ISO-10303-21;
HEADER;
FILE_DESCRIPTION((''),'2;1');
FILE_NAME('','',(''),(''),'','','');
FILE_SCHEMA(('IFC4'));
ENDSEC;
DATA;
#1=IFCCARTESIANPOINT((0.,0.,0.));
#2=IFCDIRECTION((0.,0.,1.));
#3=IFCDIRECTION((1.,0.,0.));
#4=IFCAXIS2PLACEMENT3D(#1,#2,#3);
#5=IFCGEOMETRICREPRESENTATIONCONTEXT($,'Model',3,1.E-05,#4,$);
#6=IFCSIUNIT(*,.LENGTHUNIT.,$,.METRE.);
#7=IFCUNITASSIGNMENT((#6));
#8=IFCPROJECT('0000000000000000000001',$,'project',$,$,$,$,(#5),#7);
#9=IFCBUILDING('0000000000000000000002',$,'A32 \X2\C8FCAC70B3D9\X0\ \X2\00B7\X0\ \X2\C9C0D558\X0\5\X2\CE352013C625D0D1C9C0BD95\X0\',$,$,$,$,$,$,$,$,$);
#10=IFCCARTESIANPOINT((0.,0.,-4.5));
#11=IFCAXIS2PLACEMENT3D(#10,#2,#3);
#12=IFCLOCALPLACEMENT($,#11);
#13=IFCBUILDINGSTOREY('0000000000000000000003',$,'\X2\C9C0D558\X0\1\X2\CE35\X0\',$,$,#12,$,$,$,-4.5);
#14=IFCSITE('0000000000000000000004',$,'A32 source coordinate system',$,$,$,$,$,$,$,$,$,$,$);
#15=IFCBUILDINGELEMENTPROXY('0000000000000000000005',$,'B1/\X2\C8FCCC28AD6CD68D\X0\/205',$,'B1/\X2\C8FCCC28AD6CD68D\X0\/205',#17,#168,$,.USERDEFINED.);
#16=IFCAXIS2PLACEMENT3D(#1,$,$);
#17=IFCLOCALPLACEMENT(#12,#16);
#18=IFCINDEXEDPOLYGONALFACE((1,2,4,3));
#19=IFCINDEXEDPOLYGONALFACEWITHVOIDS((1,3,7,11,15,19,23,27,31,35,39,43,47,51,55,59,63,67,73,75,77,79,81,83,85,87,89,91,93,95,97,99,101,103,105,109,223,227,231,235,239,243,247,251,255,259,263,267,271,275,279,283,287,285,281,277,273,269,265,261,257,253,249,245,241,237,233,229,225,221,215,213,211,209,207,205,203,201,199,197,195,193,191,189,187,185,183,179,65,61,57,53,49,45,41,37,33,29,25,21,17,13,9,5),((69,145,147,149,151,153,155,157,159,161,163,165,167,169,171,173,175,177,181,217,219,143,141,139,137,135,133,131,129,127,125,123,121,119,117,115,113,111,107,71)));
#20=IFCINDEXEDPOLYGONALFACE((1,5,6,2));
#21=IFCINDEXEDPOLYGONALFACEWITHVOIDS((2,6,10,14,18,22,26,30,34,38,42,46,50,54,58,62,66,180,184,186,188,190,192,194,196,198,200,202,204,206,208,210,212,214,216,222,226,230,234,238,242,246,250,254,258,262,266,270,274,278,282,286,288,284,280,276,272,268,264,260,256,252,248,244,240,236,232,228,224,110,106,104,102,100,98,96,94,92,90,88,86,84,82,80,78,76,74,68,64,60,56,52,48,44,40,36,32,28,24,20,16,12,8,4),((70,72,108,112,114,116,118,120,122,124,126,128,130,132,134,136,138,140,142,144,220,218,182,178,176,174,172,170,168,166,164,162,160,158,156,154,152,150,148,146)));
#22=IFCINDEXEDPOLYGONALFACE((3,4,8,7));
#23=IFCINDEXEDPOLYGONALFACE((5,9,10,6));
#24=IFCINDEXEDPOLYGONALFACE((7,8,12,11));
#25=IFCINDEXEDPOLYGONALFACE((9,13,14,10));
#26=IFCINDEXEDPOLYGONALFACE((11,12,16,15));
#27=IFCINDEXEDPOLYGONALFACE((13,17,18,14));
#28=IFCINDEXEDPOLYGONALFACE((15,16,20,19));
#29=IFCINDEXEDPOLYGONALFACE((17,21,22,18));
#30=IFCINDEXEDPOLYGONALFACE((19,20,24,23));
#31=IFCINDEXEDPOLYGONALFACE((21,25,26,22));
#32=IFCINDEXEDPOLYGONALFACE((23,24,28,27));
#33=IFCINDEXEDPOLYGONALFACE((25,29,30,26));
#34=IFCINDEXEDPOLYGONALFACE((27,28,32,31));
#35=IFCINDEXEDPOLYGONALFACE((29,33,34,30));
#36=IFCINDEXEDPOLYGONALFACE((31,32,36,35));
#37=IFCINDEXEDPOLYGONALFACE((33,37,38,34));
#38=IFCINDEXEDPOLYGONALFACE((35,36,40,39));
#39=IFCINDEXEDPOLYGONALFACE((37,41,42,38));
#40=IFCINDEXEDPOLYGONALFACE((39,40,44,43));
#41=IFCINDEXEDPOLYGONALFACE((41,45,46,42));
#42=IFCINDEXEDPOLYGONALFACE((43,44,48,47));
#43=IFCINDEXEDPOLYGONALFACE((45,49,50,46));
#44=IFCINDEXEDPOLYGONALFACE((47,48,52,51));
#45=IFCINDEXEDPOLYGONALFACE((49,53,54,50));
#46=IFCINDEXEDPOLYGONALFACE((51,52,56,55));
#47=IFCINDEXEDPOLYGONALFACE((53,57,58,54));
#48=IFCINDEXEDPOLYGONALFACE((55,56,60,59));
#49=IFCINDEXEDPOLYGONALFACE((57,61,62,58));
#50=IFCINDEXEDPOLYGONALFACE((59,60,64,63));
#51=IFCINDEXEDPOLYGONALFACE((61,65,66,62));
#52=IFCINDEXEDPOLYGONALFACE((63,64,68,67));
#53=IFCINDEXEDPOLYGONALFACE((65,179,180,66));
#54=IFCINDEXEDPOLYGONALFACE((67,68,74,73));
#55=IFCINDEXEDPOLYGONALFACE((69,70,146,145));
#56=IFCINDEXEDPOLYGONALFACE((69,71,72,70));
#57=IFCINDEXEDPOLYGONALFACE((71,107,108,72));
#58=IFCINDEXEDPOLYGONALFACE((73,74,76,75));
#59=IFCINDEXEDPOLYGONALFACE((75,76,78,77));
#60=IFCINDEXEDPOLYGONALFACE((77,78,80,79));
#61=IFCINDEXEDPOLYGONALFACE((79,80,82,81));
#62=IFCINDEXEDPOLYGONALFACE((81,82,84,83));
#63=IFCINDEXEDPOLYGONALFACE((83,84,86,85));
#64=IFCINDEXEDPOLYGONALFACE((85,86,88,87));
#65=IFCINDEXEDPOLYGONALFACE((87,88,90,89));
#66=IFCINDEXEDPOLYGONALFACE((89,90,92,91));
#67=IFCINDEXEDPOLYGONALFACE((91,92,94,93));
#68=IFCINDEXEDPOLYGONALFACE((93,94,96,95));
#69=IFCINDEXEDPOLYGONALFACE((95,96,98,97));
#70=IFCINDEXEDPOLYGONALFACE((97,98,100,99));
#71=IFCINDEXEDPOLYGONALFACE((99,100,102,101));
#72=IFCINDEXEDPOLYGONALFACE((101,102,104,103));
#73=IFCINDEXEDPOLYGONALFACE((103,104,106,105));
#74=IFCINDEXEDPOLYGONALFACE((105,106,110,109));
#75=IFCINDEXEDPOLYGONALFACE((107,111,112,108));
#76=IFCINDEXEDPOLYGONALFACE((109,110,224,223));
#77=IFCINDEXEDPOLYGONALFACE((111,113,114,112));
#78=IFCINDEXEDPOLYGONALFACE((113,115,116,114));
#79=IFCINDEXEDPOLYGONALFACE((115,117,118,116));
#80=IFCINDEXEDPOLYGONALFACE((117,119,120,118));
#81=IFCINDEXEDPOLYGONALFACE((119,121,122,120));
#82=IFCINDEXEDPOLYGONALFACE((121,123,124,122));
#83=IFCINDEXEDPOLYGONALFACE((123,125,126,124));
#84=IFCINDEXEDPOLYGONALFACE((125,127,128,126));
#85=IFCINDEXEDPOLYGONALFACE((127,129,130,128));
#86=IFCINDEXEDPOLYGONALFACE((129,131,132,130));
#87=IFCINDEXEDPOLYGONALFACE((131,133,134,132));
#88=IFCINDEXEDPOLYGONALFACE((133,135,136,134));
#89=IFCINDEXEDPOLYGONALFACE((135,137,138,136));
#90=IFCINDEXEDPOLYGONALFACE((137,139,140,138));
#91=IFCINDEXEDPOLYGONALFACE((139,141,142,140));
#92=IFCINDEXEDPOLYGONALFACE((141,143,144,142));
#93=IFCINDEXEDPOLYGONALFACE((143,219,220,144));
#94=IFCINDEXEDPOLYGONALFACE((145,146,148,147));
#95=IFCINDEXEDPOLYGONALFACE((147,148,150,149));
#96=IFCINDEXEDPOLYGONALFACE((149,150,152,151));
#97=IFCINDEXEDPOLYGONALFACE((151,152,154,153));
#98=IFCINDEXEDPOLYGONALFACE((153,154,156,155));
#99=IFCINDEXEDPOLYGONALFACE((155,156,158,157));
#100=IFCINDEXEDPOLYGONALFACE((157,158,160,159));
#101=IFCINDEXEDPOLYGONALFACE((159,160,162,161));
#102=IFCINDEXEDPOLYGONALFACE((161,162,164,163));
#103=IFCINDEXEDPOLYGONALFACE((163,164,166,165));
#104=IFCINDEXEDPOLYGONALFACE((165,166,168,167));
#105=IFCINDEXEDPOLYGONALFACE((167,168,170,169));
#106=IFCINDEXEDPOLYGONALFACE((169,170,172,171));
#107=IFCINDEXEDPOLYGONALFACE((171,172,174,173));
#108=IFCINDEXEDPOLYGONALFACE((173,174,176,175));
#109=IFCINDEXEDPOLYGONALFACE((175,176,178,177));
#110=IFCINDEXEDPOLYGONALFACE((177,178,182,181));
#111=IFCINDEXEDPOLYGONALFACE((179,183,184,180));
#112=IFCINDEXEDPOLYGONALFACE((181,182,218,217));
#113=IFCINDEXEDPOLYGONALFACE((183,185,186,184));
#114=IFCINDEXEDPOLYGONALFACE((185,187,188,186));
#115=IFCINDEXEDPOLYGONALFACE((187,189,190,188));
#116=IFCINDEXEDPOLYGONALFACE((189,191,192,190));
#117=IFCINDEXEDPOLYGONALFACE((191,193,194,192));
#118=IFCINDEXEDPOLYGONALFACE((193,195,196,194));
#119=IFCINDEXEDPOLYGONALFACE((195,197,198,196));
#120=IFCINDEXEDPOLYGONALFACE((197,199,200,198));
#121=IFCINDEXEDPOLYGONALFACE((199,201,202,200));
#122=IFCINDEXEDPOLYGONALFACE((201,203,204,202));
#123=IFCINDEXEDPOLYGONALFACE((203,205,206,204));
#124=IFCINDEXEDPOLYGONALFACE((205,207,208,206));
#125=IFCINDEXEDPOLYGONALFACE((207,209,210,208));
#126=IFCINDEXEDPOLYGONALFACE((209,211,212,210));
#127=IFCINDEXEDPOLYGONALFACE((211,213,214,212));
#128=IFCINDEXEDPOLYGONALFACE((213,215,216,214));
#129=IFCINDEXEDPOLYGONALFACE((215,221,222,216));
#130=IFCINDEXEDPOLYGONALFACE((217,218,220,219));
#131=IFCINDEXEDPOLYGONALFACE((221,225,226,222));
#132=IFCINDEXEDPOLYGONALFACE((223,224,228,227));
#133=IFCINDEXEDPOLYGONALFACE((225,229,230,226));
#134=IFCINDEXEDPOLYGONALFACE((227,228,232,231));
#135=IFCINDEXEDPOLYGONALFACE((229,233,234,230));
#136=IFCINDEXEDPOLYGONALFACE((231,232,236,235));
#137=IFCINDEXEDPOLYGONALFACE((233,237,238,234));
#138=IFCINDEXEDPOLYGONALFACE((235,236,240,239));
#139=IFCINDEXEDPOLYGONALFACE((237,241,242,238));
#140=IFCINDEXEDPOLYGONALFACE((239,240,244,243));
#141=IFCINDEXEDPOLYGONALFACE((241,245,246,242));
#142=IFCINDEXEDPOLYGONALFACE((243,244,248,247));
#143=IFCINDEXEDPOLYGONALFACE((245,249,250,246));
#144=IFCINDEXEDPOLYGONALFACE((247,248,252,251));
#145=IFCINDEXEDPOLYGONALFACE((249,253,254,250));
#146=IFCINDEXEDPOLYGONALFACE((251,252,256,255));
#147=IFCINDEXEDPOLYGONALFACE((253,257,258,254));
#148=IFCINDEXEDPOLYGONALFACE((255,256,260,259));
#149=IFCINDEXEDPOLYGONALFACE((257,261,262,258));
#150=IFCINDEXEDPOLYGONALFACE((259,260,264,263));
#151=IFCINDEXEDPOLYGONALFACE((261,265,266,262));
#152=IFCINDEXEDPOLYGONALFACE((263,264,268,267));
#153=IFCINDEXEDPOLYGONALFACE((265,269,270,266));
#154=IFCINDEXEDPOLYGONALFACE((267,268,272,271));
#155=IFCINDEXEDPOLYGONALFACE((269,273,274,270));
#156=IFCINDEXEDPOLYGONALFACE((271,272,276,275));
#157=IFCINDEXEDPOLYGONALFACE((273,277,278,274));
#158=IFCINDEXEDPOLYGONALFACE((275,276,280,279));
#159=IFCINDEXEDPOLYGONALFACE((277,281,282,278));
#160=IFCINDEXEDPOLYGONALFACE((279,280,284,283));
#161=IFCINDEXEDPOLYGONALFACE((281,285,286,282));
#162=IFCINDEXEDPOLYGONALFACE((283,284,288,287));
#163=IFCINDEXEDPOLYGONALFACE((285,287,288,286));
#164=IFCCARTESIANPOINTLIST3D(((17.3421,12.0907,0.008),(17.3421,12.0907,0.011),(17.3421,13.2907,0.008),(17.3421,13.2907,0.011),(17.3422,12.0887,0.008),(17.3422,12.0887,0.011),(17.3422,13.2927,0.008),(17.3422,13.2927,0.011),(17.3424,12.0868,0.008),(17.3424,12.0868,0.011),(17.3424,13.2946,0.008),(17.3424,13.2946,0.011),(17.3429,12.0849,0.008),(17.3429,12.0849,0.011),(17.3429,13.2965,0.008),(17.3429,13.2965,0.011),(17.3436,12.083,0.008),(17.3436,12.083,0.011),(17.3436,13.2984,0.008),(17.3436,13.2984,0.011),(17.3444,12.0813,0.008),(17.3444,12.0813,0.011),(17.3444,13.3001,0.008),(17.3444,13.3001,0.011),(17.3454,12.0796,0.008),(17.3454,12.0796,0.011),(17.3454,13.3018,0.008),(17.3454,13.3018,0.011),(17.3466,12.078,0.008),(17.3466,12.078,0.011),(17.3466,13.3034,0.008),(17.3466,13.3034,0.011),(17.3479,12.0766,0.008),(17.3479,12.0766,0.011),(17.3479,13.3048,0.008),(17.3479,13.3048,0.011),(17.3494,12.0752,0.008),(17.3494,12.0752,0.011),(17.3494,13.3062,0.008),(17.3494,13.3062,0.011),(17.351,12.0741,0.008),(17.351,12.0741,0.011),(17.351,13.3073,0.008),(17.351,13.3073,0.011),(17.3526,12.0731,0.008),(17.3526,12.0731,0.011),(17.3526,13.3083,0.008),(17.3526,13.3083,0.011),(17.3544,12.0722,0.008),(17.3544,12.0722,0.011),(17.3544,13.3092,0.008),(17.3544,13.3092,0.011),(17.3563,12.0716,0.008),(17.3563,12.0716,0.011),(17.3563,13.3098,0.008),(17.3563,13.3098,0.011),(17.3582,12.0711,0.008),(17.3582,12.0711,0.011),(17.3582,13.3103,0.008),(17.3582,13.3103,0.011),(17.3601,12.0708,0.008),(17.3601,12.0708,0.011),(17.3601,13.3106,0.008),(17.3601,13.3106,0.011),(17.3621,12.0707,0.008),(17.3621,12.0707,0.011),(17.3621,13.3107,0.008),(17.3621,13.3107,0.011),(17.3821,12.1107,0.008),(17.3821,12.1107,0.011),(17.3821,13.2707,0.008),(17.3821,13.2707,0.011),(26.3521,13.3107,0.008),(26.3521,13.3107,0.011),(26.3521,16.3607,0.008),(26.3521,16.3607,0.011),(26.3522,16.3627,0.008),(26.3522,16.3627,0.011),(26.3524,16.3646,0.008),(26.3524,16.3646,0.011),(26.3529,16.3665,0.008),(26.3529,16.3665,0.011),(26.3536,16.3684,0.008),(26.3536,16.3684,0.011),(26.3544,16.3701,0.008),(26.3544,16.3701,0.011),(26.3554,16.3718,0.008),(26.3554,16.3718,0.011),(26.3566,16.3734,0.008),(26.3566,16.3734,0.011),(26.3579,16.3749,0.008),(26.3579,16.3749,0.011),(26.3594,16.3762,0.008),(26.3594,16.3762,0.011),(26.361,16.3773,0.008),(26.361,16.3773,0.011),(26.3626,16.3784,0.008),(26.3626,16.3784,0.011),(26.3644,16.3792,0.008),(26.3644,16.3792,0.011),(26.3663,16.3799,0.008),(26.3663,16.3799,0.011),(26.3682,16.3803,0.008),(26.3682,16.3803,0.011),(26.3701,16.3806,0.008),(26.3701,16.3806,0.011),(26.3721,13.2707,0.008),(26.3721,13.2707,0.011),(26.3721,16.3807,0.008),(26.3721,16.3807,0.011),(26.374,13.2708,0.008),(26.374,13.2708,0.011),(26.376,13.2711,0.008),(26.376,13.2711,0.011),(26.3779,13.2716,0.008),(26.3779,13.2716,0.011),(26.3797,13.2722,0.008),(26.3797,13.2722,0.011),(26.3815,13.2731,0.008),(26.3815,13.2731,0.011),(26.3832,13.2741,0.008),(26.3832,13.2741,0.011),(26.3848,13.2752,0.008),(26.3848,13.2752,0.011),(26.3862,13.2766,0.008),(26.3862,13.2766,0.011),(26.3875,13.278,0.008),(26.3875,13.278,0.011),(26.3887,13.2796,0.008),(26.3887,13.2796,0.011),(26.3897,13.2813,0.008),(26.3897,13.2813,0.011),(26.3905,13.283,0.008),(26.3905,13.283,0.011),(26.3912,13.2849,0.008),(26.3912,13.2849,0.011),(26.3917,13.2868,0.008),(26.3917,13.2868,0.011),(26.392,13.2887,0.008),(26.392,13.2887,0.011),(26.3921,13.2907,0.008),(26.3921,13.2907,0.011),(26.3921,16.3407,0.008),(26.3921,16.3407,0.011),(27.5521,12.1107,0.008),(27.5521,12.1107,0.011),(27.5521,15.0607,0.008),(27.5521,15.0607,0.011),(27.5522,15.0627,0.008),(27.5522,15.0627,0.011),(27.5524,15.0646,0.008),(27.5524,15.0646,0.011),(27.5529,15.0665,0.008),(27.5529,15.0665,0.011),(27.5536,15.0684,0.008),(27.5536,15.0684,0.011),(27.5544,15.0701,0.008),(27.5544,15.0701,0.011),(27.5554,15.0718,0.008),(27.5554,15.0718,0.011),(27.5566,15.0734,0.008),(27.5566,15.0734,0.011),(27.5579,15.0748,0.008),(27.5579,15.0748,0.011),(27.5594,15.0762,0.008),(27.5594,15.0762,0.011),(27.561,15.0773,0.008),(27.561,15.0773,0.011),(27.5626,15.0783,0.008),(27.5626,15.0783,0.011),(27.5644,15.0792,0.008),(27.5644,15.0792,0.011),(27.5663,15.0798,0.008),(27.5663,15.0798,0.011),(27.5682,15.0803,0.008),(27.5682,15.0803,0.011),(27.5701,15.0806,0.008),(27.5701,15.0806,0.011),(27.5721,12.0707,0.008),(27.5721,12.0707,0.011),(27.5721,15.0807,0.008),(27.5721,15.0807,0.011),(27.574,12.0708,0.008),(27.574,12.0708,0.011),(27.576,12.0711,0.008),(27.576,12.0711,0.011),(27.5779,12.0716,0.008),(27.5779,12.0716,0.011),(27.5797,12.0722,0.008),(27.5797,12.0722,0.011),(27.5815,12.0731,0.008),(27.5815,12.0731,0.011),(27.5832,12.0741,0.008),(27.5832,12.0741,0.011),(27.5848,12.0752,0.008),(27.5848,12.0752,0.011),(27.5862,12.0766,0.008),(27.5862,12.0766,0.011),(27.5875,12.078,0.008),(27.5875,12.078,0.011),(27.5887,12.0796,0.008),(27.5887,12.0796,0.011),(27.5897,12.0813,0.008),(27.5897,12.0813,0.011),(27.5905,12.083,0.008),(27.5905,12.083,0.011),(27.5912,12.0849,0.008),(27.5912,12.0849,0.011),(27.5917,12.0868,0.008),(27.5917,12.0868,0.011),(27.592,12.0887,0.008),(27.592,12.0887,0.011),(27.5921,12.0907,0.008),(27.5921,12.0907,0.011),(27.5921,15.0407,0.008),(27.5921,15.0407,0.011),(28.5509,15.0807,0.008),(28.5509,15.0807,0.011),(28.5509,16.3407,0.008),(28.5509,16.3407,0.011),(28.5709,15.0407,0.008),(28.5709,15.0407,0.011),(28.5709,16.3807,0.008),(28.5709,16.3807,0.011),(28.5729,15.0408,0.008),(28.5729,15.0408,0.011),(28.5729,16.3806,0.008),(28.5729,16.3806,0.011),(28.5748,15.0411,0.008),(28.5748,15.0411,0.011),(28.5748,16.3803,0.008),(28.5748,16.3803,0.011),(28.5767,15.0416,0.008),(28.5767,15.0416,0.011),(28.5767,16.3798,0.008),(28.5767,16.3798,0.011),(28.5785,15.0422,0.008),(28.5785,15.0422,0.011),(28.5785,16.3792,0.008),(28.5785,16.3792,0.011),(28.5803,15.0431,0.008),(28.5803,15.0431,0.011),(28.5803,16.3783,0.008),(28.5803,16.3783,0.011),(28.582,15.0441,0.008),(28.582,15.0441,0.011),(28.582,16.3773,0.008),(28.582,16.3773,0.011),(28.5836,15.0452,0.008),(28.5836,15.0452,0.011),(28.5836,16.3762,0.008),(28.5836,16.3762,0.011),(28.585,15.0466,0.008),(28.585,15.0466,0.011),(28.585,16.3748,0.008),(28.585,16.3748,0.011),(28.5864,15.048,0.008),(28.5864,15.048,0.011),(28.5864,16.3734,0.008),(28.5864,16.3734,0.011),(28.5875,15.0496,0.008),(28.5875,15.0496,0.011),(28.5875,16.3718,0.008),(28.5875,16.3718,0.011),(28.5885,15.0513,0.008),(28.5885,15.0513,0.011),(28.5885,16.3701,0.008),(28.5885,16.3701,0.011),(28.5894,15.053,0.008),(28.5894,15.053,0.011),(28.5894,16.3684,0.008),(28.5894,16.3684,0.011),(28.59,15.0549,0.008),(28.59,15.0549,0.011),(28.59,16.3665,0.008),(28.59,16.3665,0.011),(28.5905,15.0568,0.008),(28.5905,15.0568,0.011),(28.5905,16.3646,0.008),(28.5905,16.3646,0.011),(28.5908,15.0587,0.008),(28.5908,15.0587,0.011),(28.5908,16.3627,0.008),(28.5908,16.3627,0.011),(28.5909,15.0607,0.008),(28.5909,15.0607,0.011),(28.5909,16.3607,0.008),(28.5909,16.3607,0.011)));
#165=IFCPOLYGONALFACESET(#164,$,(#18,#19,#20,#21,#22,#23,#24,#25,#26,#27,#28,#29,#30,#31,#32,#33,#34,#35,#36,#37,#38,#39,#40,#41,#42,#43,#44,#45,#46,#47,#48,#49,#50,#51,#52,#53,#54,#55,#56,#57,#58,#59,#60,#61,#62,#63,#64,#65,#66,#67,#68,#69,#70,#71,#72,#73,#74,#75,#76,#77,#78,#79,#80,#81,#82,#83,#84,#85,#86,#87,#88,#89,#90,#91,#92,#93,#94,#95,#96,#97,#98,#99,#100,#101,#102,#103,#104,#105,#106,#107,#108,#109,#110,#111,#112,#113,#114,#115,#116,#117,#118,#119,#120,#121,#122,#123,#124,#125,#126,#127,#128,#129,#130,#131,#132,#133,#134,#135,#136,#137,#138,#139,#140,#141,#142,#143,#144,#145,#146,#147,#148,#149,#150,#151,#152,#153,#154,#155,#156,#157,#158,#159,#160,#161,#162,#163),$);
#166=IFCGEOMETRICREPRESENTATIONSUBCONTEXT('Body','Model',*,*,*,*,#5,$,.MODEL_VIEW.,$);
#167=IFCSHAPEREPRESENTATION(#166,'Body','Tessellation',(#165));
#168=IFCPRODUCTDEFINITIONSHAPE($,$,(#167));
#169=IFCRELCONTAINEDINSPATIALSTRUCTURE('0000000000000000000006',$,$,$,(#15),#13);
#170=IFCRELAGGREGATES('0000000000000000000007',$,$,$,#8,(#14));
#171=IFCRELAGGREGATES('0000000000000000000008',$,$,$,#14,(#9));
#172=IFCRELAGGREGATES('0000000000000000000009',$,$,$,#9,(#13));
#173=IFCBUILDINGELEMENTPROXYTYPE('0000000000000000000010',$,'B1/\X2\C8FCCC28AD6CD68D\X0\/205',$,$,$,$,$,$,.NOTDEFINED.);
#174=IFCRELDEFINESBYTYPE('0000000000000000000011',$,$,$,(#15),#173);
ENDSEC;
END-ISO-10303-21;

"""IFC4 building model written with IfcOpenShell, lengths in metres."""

from ifc_helpers import new_model, si_unit, frame, origin, origin_with_axes, place, context, subcontext, project, spatial, polyline, outline, extrude, source, transform, mapped, type_object, type_shapes, element, save


model = new_model("IFC4")

# Units and contexts
model_context = context("Model", 3, precision=1e-05, world=origin_with_axes())
body_context = subcontext(model_context, "Body", "Model", "MODEL_VIEW")
ifc_project = project(units=[si_unit("LENGTHUNIT", "METRE")], contexts=[model_context])

# Site, building, storey
site = spatial("IfcSite", under=ifc_project, Name="A32 source coordinate system")
building = spatial("IfcBuilding", under=site, Name="A32 주거동 · 지하5층–옥탑지붕")
storey_placement = place(None, frame((0.0, 0.0, -4.5), z_axis=(0.0, 0.0, 1.0), x_axis=(1.0, 0.0, 0.0)))
storey = spatial("IfcBuildingStorey", under=building, at=storey_placement, Name="지하1층", Elevation=-4.5)

# Building element proxy
building_element_proxy_type_1 = type_object("IfcBuildingElementProxyType", Name="B1/주차구획/205", PredefinedType="NOTDEFINED")
shared_shape_1 = source(origin(), body_context, "Body", "SweptSolid", [
    extrude(outline(polyline([(28.5709, 16.3807), (28.5729, 16.3806), (28.5748, 16.3803), (28.5767, 16.3798), (28.5785, 16.3792), (28.5803, 16.3783), (28.582, 16.3773), (28.5836, 16.3762), (28.585, 16.3748), (28.5864, 16.3734), (28.5875, 16.3718), (28.5885, 16.3701), (28.5894, 16.3684), (28.59, 16.3665), (28.5905, 16.3646), (28.5908, 16.3627), (28.5909, 16.3607), (28.5909, 15.0607), (28.5908, 15.0587), (28.5905, 15.0568), (28.59, 15.0549), (28.5894, 15.053), (28.5885, 15.0513), (28.5875, 15.0496), (28.5864, 15.048), (28.585, 15.0466), (28.5836, 15.0452), (28.582, 15.0441), (28.5803, 15.0431), (28.5785, 15.0422), (28.5767, 15.0416), (28.5748, 15.0411), (28.5729, 15.0408), (28.5709, 15.0407), (27.5921, 15.0407), (27.5921, 12.0907), (27.592, 12.0887), (27.5917, 12.0868), (27.5912, 12.0849), (27.5905, 12.083), (27.5897, 12.0813), (27.5887, 12.0796), (27.5875, 12.078), (27.5862, 12.0766), (27.5848, 12.0752), (27.5832, 12.0741), (27.5815, 12.0731), (27.5797, 12.0722), (27.5779, 12.0716), (27.576, 12.0711), (27.574, 12.0708), (27.5721, 12.0707), (17.3621, 12.0707), (17.3601, 12.0708), (17.3582, 12.0711), (17.3563, 12.0716), (17.3544, 12.0722), (17.3526, 12.0731), (17.351, 12.0741), (17.3494, 12.0752), (17.3479, 12.0766), (17.3466, 12.078), (17.3454, 12.0796), (17.3444, 12.0813), (17.3436, 12.083), (17.3429, 12.0849), (17.3424, 12.0868), (17.3422, 12.0887), (17.3421, 12.0907), (17.3421, 13.2907), (17.3422, 13.2927), (17.3424, 13.2946), (17.3429, 13.2965), (17.3436, 13.2984), (17.3444, 13.3001), (17.3454, 13.3018), (17.3466, 13.3034), (17.3479, 13.3048), (17.3494, 13.3062), (17.351, 13.3073), (17.3526, 13.3083), (17.3544, 13.3092), (17.3563, 13.3098), (17.3582, 13.3103), (17.3601, 13.3106), (17.3621, 13.3107), (26.3521, 13.3107), (26.3521, 16.3607), (26.3522, 16.3627), (26.3524, 16.3646), (26.3529, 16.3665), (26.3536, 16.3684), (26.3544, 16.3701), (26.3554, 16.3718), (26.3566, 16.3734), (26.3579, 16.3749), (26.3594, 16.3762), (26.361, 16.3773), (26.3626, 16.3784), (26.3644, 16.3792), (26.3663, 16.3799), (26.3682, 16.3803), (26.3701, 16.3806), (26.3721, 16.3807), (28.5709, 16.3807)]), holes=[polyline([(28.5509, 16.3407), (26.3921, 16.3407), (26.3921, 13.2907), (26.392, 13.2887), (26.3917, 13.2868), (26.3912, 13.2849), (26.3905, 13.283), (26.3897, 13.2813), (26.3887, 13.2796), (26.3875, 13.278), (26.3862, 13.2766), (26.3848, 13.2752), (26.3832, 13.2741), (26.3815, 13.2731), (26.3797, 13.2722), (26.3779, 13.2716), (26.376, 13.2711), (26.374, 13.2708), (26.3721, 13.2707), (17.3821, 13.2707), (17.3821, 12.1107), (27.5521, 12.1107), (27.5521, 15.0607), (27.5522, 15.0627), (27.5524, 15.0646), (27.5529, 15.0665), (27.5536, 15.0684), (27.5544, 15.0701), (27.5554, 15.0718), (27.5566, 15.0734), (27.5579, 15.0748), (27.5594, 15.0762), (27.561, 15.0773), (27.5626, 15.0783), (27.5644, 15.0792), (27.5663, 15.0798), (27.5682, 15.0803), (27.5701, 15.0806), (27.5721, 15.0807), (28.5509, 15.0807), (28.5509, 16.3407)])]), frame((0.0, 0.0, 0.008)), (0.0, 0.0, 1.0), 0.003),
])
type_shapes(building_element_proxy_type_1, [shared_shape_1])
proxy_1_placement = place(storey_placement, origin_with_axes())
element("IfcBuildingElementProxy", 1, at=proxy_1_placement, inside=storey, type_object=building_element_proxy_type_1, Name="B1/주차구획/205", ObjectType="B1/주차구획/205", PredefinedType="USERDEFINED", context=body_context, shape_type="MappedRepresentation", body=[
    mapped(shared_shape_1, transform((0.0, 0.0, 0.0), scale=1.0)),
])

save(model, "model.ifc")
